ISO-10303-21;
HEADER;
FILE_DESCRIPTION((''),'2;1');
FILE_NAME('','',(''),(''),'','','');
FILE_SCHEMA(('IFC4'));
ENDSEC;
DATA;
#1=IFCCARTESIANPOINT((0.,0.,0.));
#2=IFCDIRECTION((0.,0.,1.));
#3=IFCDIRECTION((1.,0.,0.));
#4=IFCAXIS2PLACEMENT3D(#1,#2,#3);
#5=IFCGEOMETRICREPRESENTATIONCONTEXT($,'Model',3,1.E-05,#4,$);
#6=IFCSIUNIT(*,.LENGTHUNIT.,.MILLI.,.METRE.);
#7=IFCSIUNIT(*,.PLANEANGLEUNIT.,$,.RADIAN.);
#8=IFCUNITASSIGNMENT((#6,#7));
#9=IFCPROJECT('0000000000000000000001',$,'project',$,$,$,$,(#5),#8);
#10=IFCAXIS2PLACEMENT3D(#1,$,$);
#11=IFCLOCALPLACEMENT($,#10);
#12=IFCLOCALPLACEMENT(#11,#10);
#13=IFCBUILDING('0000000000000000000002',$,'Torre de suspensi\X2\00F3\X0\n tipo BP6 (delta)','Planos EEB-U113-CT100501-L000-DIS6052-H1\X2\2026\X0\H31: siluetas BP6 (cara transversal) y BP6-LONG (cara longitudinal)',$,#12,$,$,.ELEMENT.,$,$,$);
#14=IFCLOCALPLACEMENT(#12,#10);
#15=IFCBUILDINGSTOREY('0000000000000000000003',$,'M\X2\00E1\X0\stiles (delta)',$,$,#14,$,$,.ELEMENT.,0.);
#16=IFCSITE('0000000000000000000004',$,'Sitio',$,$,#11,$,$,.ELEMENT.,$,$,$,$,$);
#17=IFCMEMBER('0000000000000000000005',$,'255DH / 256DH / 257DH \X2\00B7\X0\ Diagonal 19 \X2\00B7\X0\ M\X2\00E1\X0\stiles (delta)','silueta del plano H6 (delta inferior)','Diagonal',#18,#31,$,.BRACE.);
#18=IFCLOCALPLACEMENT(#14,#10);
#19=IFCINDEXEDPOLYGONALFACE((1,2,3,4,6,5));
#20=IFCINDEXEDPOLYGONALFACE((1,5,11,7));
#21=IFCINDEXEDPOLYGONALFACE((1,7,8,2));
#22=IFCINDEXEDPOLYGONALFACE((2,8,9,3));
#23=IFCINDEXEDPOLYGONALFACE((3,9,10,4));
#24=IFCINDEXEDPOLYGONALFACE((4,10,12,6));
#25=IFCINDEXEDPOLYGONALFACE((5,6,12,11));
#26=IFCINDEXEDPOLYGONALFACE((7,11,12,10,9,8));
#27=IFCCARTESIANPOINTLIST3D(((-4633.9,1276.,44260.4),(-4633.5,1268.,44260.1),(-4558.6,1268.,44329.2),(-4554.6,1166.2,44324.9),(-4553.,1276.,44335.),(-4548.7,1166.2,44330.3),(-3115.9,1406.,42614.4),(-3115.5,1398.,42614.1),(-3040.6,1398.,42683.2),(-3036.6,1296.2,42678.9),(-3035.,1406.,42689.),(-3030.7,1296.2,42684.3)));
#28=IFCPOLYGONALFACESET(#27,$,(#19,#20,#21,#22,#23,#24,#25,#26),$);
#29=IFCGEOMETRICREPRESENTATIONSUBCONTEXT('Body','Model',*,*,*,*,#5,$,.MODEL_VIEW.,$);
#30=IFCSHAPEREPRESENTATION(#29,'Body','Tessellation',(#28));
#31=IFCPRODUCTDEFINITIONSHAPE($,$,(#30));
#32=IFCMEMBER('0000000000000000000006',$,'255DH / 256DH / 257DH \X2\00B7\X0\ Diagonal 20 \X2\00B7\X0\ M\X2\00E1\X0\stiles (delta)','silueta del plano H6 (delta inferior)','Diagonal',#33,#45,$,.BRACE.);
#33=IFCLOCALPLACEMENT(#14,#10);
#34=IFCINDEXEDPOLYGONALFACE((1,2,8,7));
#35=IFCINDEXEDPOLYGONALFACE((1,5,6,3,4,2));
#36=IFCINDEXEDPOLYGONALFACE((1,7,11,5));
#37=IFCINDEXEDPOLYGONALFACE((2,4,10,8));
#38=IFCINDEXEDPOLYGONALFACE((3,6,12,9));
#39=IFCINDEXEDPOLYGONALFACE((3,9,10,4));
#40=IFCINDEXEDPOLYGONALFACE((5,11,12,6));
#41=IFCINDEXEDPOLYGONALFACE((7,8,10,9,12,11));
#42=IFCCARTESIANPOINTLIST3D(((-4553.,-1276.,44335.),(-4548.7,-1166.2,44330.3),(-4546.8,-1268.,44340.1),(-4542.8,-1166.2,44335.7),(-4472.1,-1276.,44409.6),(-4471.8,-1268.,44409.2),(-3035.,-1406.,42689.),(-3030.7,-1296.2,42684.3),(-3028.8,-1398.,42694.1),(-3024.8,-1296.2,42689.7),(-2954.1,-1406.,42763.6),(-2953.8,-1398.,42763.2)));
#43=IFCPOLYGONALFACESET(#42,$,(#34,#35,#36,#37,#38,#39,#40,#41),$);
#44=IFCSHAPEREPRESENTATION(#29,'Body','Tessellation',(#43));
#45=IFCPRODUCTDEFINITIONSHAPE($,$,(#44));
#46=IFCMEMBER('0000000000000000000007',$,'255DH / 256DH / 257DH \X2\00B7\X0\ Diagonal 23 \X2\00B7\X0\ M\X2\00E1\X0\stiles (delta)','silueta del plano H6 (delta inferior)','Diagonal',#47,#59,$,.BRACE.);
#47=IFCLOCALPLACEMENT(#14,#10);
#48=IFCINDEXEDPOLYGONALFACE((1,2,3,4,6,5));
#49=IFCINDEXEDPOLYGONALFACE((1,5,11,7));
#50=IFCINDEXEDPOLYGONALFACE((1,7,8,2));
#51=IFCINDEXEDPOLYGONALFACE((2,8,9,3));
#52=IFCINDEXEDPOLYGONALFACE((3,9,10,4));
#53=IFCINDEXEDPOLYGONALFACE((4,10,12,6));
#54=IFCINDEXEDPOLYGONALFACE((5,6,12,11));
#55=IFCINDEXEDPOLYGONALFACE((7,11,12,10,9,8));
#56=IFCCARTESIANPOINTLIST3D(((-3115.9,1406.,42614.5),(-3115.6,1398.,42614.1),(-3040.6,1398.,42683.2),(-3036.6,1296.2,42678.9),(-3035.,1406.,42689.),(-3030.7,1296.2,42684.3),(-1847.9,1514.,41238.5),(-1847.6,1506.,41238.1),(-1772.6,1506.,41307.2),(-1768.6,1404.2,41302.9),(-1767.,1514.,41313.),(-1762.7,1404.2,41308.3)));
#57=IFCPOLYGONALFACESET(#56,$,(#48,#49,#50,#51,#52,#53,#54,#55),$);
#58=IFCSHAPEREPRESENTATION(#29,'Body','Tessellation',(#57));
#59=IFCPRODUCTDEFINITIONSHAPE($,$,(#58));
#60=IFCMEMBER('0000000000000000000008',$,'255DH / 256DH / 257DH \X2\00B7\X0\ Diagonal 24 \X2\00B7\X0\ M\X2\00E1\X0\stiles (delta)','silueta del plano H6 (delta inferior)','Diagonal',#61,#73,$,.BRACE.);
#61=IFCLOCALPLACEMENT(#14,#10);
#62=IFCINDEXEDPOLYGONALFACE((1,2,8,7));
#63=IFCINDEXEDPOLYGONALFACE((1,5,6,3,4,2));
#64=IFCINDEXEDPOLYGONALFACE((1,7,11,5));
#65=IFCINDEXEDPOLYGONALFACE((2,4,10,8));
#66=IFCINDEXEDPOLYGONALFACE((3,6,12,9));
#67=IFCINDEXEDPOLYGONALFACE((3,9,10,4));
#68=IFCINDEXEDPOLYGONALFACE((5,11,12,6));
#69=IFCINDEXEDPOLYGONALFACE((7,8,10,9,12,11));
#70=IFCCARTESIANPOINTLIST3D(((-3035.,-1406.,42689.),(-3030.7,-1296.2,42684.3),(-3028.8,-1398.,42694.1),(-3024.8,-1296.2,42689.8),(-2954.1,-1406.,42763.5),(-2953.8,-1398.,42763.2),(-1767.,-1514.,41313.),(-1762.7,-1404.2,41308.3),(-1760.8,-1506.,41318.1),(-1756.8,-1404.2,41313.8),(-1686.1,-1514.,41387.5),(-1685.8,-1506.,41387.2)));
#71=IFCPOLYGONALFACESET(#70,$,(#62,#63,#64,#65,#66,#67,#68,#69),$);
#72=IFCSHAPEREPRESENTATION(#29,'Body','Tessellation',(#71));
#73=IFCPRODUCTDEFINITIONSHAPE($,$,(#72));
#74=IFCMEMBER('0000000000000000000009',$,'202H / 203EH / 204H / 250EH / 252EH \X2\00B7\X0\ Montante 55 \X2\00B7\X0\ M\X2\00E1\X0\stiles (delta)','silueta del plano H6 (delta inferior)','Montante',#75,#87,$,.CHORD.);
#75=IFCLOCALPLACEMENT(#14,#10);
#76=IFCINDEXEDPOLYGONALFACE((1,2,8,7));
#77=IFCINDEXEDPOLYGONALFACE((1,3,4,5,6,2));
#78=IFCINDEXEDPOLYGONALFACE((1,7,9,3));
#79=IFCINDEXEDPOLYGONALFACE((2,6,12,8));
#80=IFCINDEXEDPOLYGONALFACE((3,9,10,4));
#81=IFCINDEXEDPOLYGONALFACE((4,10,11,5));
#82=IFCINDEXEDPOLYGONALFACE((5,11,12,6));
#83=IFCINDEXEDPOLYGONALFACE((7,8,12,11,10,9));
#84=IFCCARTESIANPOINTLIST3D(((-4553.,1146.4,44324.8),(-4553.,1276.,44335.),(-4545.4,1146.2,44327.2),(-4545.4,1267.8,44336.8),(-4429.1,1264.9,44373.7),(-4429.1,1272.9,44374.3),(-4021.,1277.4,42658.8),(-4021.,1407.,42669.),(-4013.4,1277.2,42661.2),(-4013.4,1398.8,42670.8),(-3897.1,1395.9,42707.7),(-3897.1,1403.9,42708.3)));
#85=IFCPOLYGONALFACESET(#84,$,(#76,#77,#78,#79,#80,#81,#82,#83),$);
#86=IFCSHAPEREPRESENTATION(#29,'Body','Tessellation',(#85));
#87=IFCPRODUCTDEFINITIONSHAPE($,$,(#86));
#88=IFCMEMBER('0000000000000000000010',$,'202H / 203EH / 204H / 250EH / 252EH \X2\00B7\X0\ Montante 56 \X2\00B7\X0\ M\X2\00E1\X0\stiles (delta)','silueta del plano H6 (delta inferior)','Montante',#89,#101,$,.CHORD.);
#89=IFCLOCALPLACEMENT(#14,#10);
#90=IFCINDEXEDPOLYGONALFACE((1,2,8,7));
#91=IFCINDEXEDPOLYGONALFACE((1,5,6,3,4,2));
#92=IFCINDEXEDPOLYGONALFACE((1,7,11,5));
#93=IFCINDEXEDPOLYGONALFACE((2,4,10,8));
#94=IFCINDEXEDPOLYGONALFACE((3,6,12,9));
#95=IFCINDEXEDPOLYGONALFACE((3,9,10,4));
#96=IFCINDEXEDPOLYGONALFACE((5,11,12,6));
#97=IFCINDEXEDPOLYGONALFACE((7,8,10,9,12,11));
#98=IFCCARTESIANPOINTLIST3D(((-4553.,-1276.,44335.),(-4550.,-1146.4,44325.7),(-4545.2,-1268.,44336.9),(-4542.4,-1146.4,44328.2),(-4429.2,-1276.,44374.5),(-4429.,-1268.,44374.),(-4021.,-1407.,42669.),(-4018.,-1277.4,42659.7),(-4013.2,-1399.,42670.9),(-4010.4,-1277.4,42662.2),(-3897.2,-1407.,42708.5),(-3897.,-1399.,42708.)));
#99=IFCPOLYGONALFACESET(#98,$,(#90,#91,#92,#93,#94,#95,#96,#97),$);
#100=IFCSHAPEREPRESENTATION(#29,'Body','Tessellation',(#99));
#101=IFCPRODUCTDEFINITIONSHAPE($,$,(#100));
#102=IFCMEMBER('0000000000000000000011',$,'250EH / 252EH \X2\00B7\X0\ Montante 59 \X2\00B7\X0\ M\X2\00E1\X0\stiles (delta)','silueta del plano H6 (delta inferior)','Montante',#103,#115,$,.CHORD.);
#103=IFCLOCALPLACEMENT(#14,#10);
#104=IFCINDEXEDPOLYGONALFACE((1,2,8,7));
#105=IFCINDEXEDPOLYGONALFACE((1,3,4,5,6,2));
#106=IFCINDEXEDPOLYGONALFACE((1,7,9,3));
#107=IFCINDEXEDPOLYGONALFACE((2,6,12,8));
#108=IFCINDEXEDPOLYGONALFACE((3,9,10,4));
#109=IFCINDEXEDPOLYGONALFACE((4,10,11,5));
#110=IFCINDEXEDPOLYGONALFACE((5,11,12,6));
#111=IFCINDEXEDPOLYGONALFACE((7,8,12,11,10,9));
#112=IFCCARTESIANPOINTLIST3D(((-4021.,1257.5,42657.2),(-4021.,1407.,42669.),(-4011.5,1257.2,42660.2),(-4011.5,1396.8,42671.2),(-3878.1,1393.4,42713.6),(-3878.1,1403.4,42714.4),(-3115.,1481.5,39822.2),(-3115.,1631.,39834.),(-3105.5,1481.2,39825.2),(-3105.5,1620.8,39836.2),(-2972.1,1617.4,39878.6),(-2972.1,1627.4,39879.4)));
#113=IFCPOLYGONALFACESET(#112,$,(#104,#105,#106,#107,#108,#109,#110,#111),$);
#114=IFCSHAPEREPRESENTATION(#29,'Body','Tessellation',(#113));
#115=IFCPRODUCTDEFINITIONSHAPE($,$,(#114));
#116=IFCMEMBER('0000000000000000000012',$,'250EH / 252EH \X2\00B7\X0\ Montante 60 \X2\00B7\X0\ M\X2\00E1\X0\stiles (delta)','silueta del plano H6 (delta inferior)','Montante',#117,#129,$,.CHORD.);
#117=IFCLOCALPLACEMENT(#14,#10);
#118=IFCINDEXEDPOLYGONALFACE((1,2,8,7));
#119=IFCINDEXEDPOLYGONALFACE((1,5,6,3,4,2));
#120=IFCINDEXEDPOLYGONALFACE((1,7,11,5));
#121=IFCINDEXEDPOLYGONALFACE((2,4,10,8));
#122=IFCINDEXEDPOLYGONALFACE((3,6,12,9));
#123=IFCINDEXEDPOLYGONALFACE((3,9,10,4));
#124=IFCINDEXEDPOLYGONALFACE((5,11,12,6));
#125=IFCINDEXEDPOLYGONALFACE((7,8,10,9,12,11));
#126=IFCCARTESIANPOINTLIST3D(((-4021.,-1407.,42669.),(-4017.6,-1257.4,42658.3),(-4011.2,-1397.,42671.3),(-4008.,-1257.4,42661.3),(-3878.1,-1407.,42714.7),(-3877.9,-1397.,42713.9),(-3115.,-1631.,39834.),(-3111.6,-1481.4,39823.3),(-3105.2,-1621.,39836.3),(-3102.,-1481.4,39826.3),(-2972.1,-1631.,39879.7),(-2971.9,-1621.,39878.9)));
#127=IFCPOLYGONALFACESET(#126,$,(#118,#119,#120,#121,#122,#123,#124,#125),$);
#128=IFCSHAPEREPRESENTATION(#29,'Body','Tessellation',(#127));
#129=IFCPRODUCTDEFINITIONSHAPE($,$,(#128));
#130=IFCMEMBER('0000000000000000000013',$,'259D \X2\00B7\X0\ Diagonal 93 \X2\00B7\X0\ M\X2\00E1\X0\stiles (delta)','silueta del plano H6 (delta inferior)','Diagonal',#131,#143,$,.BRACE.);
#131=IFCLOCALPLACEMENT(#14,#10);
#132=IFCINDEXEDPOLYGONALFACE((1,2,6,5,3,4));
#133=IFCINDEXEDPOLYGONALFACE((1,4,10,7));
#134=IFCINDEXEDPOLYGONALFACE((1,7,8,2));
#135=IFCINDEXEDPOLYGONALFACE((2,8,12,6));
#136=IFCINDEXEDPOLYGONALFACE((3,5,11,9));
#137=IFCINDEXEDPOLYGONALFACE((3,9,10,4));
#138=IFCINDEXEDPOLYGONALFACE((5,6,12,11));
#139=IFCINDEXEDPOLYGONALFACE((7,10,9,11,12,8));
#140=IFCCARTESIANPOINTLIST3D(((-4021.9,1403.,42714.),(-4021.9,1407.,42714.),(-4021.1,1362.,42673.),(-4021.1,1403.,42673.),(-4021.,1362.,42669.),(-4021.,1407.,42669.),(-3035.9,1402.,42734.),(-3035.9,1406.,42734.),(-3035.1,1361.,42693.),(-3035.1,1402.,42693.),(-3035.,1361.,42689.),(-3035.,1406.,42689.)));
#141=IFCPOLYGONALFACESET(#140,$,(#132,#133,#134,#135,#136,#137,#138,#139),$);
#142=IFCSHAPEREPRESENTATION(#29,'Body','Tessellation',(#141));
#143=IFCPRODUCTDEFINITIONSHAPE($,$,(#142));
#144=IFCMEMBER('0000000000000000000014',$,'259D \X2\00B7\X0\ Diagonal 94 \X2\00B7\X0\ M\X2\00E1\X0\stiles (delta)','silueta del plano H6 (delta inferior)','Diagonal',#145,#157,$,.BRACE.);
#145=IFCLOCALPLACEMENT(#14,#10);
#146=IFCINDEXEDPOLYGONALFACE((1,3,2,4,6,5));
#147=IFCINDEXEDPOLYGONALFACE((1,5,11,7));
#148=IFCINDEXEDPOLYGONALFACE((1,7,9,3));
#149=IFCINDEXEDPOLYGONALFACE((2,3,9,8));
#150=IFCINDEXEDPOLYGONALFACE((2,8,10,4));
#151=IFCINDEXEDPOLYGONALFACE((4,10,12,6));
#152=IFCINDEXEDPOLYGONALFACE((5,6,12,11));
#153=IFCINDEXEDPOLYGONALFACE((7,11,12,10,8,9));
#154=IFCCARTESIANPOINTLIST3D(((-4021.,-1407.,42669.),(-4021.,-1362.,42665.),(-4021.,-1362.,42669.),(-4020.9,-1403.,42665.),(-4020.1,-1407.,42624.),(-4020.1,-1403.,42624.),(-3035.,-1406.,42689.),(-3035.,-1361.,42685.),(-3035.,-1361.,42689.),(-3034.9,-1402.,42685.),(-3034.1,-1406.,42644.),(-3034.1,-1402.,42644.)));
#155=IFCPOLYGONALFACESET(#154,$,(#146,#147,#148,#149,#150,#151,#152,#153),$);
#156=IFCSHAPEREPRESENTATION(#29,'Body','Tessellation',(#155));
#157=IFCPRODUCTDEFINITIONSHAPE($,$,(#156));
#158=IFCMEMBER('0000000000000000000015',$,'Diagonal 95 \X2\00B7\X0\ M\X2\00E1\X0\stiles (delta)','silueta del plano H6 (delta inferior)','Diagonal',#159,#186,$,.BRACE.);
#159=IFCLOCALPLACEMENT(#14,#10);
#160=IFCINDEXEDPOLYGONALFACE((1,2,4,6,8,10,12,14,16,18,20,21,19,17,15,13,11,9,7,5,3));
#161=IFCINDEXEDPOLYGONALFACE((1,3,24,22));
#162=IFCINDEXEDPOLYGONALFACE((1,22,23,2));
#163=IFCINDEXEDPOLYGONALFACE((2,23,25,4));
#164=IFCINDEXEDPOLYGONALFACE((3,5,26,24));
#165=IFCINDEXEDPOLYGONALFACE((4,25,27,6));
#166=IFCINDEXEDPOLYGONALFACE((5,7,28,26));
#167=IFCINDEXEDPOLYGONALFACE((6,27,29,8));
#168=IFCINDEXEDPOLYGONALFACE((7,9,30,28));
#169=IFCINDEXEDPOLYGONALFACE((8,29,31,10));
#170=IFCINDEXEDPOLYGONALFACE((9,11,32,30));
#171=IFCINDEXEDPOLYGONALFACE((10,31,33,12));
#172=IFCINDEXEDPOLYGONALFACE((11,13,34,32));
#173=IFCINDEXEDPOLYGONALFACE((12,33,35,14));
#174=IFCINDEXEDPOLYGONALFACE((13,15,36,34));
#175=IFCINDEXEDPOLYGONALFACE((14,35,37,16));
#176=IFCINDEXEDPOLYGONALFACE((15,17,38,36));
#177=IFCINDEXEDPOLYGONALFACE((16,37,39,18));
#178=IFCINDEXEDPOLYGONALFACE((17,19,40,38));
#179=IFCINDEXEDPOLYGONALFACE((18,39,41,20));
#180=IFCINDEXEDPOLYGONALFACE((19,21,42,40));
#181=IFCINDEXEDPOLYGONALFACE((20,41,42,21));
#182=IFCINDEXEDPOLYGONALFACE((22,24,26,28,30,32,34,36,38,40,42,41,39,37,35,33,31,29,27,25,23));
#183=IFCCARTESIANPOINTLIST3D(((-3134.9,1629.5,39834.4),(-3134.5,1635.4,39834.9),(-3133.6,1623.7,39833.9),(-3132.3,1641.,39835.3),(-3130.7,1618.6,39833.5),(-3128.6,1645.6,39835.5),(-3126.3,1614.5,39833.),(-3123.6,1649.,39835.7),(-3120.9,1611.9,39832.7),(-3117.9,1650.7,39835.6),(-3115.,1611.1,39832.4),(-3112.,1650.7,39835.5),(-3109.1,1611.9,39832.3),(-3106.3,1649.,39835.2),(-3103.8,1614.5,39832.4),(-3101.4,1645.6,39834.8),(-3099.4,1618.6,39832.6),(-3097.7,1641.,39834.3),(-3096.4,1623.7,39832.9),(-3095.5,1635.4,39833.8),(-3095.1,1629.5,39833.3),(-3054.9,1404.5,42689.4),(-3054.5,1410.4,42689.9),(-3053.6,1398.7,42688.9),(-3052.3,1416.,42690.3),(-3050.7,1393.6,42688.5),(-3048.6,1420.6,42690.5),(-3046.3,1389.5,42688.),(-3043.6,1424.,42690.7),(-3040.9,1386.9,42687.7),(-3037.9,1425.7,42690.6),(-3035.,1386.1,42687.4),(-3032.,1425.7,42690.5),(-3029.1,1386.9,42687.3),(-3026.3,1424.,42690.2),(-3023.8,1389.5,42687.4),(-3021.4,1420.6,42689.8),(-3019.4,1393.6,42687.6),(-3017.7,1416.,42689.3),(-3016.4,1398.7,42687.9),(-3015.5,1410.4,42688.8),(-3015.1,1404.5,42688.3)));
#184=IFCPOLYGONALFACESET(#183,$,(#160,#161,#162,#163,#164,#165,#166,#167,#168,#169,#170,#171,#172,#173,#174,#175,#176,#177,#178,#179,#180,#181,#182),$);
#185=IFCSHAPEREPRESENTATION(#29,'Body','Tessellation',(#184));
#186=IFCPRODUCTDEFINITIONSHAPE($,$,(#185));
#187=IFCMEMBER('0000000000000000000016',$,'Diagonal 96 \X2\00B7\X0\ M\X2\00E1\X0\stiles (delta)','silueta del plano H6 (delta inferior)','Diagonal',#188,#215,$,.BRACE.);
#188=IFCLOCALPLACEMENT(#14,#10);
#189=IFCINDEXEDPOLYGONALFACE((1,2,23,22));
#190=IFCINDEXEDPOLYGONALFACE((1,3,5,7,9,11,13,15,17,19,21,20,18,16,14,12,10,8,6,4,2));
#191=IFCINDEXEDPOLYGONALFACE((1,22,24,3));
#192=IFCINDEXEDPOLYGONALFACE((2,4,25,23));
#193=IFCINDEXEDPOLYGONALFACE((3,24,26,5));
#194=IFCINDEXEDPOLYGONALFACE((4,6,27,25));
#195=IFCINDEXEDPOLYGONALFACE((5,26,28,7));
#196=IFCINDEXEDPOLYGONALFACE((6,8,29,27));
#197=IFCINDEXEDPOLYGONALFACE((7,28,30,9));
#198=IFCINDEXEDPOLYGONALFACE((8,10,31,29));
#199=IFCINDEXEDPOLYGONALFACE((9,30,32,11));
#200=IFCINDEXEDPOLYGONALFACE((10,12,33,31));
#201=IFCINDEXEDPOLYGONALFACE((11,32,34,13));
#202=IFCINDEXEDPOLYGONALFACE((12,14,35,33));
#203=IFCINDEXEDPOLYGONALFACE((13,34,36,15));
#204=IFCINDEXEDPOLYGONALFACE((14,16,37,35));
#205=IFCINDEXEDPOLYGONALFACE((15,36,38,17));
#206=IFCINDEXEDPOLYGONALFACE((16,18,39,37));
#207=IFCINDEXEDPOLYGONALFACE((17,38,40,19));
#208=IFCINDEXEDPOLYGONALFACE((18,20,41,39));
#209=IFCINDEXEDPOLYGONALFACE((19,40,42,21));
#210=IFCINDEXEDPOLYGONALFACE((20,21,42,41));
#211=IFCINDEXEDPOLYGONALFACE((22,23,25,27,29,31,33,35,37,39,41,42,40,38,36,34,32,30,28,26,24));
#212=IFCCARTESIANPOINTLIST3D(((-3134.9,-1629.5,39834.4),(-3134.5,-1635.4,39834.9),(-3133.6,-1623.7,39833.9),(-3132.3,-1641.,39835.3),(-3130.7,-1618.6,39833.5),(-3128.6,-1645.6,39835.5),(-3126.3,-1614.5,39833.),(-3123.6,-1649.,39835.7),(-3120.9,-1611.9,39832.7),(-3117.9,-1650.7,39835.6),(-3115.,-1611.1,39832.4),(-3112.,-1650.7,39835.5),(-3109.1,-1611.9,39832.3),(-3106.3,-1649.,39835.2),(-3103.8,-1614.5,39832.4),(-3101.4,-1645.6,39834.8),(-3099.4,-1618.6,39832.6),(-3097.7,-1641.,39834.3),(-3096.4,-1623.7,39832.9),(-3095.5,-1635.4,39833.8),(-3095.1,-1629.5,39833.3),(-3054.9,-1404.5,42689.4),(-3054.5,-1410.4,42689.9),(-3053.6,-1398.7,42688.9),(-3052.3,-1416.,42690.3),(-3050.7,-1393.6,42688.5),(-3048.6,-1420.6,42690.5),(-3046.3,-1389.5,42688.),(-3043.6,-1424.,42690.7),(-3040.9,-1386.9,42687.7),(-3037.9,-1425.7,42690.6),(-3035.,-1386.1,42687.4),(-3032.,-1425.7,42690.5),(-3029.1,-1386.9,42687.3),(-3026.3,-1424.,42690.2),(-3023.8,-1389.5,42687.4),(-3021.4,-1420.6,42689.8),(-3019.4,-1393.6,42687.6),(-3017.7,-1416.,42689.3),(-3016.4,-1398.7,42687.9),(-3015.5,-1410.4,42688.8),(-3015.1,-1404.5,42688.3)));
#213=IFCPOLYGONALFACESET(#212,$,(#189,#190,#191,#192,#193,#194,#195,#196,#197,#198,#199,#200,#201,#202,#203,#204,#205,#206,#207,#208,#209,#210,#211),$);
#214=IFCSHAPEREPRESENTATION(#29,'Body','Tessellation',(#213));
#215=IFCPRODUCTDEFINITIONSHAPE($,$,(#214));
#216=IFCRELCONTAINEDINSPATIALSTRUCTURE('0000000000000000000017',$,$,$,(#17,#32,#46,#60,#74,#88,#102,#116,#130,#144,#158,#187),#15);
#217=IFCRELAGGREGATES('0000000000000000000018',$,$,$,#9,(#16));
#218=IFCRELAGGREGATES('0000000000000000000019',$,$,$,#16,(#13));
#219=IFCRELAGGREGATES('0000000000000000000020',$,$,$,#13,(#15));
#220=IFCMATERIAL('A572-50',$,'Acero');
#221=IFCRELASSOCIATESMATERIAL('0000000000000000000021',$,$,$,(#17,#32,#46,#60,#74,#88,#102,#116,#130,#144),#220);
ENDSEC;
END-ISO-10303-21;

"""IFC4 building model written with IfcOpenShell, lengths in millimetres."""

from ifc_helpers import new_model, si_unit, frame, frame_2d, origin, origin_with_axes, place, context, subcontext, project, spatial, circle, l_section, extrude, material, element, save


model = new_model("IFC4")

# Units and contexts
model_context = context("Model", 3, precision=1e-05, world=origin_with_axes())
body_context = subcontext(model_context, "Body", "Model", "MODEL_VIEW")
ifc_project = project(units=[si_unit("LENGTHUNIT", "METRE", prefix="MILLI"), si_unit("PLANEANGLEUNIT", "RADIAN")], contexts=[model_context])

# Site, building, storey
site_placement = place(None, origin())
site = spatial("IfcSite", under=ifc_project, at=site_placement, Name="Sitio", CompositionType="ELEMENT")
building_placement = place(site_placement, origin())
building = spatial("IfcBuilding", under=site, at=building_placement, Name="Torre de suspensión tipo BP6 (delta)", Description="Planos EEB-U113-CT100501-L000-DIS6052-H1…H31: siluetas BP6 (cara transversal) y BP6-LONG (cara longitudinal)", CompositionType="ELEMENT")
storey_placement = place(building_placement, origin())
storey = spatial("IfcBuildingStorey", under=building, at=storey_placement, Name="Mástiles (delta)", CompositionType="ELEMENT", Elevation=0.0)

# Members
ifc_material = material(Name="A572-50", Category="Acero")
for number, where, z_axis, x_axis, name in (
    (1, (-4553.0, 1276.0, 44335.0), (0.676806, 0.057961, -0.733876), (0.039294, -0.998319, -0.042608), "255DH / 256DH / 257DH · Diagonal 19 · Mástiles (delta)"),
    (2, (-4553.0, -1276.0, 44335.0), (0.676806, -0.057961, -0.733876), (0.039294, 0.998319, -0.042608), "255DH / 256DH / 257DH · Diagonal 20 · Mástiles (delta)"),
):
    element("IfcMember", number, at=place(storey_placement, frame(where, z_axis=z_axis, x_axis=x_axis)), inside=storey, material=ifc_material, Name=name, Description="silueta del plano H6 (delta inferior)", ObjectType="Diagonal", PredefinedType="BRACE", context=body_context, shape_type="SweptSolid", body=[
        extrude(l_section(Depth=110.0, Width=110.0, Thickness=8.0, at=frame_2d((55.0, 55.0))), None, (0.0, 0.0, 1.0), 2242.9),
    ])
for number, where, z_axis, x_axis, name in (
    (3, (-3035.0, 1406.0, 42689.0), (0.676532, 0.057623, -0.734155), (0.039048, -0.998338, -0.042374), "255DH / 256DH / 257DH · Diagonal 23 · Mástiles (delta)"),
    (4, (-3035.0, -1406.0, 42689.0), (0.676532, -0.057623, -0.734155), (0.039048, 0.998338, -0.042374), "255DH / 256DH / 257DH · Diagonal 24 · Mástiles (delta)"),
):
    element("IfcMember", number, at=place(storey_placement, frame(where, z_axis=z_axis, x_axis=x_axis)), inside=storey, material=ifc_material, Name=name, Description="silueta del plano H6 (delta inferior)", ObjectType="Diagonal", PredefinedType="BRACE", context=body_context, shape_type="SweptSolid", body=[
        extrude(l_section(Depth=110.0, Width=110.0, Thickness=8.0, at=frame_2d((55.0, 55.0))), None, (0.0, 0.0, 1.0), 1874.3),
    ])
for number, where, z_axis, x_axis, name in (
    (5, (-4553.0, 1276.0, 44335.0), (0.303345, 0.074696, -0.949949), (0.952881, -0.023779, 0.302411), "202H / 203EH / 204H / 250EH / 252EH · Montante 55 · Mástiles (delta)"),
    (6, (-4553.0, -1276.0, 44335.0), (0.303345, -0.074696, -0.949949), (0.022722, 0.997206, -0.071156), "202H / 203EH / 204H / 250EH / 252EH · Montante 56 · Mástiles (delta)"),
):
    element("IfcMember", number, at=place(storey_placement, frame(where, z_axis=z_axis, x_axis=x_axis)), inside=storey, material=ifc_material, Name=name, Description="silueta del plano H6 (delta inferior)", ObjectType="Montante", PredefinedType="CHORD", context=body_context, shape_type="SweptSolid", body=[
        extrude(l_section(Depth=130.0, Width=130.0, Thickness=8.0, at=frame_2d((65.0, 65.0))), None, (0.0, 0.0, 1.0), 1753.8),
    ])
for number, where, z_axis, x_axis, name in (
    (7, (-4021.0, 1407.0, 42669.0), (0.303551, 0.07505, -0.949855), (0.952815, -0.02391, 0.302608), "250EH / 252EH · Montante 59 · Mástiles (delta)"),
    (8, (-4021.0, -1407.0, 42669.0), (0.303551, -0.07505, -0.949855), (0.022846, 0.99718, -0.071488), "250EH / 252EH · Montante 60 · Mástiles (delta)"),
):
    element("IfcMember", number, at=place(storey_placement, frame(where, z_axis=z_axis, x_axis=x_axis)), inside=storey, material=ifc_material, Name=name, Description="silueta del plano H6 (delta inferior)", ObjectType="Montante", PredefinedType="CHORD", context=body_context, shape_type="SweptSolid", body=[
        extrude(l_section(Depth=150.0, Width=150.0, Thickness=10.0, at=frame_2d((75.0, 75.0))), None, (0.0, 0.0, 1.0), 2984.7),
    ])
for number, where, z_axis, x_axis, name in (
    (9, (-3035.0, 1406.0, 42689.0), (-0.999794, 0.001014, -0.02028), (-0.001014, -0.999999, -0.000021), "259D · Diagonal 93 · Mástiles (delta)"),
    (10, (-3035.0, -1406.0, 42689.0), (-0.999794, -0.001014, -0.02028), (-0.001014, 0.999999, -0.000021), "259D · Diagonal 94 · Mástiles (delta)"),
):
    element("IfcMember", number, at=place(storey_placement, frame(where, z_axis=z_axis, x_axis=x_axis)), inside=storey, material=ifc_material, Name=name, Description="silueta del plano H6 (delta inferior)", ObjectType="Diagonal", PredefinedType="BRACE", context=body_context, shape_type="SweptSolid", body=[
        extrude(l_section(Depth=45.0, Width=45.0, Thickness=4.0, at=frame_2d((22.5, 22.5))), None, (0.0, 0.0, 1.0), 986.2),
    ])
for number, where, z_axis, x_axis, name in (
    (11, (-3035.0, 1406.0, 42689.0), (-0.027924, 0.078535, -0.99652), (-0.0022, -0.996911, -0.078504), "Diagonal 95 · Mástiles (delta)"),
    (12, (-3035.0, -1406.0, 42689.0), (-0.027924, -0.078535, -0.99652), (-0.0022, 0.996911, -0.078504), "Diagonal 96 · Mástiles (delta)"),
):
    element("IfcMember", number, at=place(storey_placement, frame(where, z_axis=z_axis, x_axis=x_axis)), inside=storey, Name=name, Description="silueta del plano H6 (delta inferior)", ObjectType="Diagonal", PredefinedType="BRACE", context=body_context, shape_type="SweptSolid", body=[
        extrude(circle(Radius=20.0), None, (0.0, 0.0, 1.0), 2865.0),
    ])

save(model, "model.ifc")
